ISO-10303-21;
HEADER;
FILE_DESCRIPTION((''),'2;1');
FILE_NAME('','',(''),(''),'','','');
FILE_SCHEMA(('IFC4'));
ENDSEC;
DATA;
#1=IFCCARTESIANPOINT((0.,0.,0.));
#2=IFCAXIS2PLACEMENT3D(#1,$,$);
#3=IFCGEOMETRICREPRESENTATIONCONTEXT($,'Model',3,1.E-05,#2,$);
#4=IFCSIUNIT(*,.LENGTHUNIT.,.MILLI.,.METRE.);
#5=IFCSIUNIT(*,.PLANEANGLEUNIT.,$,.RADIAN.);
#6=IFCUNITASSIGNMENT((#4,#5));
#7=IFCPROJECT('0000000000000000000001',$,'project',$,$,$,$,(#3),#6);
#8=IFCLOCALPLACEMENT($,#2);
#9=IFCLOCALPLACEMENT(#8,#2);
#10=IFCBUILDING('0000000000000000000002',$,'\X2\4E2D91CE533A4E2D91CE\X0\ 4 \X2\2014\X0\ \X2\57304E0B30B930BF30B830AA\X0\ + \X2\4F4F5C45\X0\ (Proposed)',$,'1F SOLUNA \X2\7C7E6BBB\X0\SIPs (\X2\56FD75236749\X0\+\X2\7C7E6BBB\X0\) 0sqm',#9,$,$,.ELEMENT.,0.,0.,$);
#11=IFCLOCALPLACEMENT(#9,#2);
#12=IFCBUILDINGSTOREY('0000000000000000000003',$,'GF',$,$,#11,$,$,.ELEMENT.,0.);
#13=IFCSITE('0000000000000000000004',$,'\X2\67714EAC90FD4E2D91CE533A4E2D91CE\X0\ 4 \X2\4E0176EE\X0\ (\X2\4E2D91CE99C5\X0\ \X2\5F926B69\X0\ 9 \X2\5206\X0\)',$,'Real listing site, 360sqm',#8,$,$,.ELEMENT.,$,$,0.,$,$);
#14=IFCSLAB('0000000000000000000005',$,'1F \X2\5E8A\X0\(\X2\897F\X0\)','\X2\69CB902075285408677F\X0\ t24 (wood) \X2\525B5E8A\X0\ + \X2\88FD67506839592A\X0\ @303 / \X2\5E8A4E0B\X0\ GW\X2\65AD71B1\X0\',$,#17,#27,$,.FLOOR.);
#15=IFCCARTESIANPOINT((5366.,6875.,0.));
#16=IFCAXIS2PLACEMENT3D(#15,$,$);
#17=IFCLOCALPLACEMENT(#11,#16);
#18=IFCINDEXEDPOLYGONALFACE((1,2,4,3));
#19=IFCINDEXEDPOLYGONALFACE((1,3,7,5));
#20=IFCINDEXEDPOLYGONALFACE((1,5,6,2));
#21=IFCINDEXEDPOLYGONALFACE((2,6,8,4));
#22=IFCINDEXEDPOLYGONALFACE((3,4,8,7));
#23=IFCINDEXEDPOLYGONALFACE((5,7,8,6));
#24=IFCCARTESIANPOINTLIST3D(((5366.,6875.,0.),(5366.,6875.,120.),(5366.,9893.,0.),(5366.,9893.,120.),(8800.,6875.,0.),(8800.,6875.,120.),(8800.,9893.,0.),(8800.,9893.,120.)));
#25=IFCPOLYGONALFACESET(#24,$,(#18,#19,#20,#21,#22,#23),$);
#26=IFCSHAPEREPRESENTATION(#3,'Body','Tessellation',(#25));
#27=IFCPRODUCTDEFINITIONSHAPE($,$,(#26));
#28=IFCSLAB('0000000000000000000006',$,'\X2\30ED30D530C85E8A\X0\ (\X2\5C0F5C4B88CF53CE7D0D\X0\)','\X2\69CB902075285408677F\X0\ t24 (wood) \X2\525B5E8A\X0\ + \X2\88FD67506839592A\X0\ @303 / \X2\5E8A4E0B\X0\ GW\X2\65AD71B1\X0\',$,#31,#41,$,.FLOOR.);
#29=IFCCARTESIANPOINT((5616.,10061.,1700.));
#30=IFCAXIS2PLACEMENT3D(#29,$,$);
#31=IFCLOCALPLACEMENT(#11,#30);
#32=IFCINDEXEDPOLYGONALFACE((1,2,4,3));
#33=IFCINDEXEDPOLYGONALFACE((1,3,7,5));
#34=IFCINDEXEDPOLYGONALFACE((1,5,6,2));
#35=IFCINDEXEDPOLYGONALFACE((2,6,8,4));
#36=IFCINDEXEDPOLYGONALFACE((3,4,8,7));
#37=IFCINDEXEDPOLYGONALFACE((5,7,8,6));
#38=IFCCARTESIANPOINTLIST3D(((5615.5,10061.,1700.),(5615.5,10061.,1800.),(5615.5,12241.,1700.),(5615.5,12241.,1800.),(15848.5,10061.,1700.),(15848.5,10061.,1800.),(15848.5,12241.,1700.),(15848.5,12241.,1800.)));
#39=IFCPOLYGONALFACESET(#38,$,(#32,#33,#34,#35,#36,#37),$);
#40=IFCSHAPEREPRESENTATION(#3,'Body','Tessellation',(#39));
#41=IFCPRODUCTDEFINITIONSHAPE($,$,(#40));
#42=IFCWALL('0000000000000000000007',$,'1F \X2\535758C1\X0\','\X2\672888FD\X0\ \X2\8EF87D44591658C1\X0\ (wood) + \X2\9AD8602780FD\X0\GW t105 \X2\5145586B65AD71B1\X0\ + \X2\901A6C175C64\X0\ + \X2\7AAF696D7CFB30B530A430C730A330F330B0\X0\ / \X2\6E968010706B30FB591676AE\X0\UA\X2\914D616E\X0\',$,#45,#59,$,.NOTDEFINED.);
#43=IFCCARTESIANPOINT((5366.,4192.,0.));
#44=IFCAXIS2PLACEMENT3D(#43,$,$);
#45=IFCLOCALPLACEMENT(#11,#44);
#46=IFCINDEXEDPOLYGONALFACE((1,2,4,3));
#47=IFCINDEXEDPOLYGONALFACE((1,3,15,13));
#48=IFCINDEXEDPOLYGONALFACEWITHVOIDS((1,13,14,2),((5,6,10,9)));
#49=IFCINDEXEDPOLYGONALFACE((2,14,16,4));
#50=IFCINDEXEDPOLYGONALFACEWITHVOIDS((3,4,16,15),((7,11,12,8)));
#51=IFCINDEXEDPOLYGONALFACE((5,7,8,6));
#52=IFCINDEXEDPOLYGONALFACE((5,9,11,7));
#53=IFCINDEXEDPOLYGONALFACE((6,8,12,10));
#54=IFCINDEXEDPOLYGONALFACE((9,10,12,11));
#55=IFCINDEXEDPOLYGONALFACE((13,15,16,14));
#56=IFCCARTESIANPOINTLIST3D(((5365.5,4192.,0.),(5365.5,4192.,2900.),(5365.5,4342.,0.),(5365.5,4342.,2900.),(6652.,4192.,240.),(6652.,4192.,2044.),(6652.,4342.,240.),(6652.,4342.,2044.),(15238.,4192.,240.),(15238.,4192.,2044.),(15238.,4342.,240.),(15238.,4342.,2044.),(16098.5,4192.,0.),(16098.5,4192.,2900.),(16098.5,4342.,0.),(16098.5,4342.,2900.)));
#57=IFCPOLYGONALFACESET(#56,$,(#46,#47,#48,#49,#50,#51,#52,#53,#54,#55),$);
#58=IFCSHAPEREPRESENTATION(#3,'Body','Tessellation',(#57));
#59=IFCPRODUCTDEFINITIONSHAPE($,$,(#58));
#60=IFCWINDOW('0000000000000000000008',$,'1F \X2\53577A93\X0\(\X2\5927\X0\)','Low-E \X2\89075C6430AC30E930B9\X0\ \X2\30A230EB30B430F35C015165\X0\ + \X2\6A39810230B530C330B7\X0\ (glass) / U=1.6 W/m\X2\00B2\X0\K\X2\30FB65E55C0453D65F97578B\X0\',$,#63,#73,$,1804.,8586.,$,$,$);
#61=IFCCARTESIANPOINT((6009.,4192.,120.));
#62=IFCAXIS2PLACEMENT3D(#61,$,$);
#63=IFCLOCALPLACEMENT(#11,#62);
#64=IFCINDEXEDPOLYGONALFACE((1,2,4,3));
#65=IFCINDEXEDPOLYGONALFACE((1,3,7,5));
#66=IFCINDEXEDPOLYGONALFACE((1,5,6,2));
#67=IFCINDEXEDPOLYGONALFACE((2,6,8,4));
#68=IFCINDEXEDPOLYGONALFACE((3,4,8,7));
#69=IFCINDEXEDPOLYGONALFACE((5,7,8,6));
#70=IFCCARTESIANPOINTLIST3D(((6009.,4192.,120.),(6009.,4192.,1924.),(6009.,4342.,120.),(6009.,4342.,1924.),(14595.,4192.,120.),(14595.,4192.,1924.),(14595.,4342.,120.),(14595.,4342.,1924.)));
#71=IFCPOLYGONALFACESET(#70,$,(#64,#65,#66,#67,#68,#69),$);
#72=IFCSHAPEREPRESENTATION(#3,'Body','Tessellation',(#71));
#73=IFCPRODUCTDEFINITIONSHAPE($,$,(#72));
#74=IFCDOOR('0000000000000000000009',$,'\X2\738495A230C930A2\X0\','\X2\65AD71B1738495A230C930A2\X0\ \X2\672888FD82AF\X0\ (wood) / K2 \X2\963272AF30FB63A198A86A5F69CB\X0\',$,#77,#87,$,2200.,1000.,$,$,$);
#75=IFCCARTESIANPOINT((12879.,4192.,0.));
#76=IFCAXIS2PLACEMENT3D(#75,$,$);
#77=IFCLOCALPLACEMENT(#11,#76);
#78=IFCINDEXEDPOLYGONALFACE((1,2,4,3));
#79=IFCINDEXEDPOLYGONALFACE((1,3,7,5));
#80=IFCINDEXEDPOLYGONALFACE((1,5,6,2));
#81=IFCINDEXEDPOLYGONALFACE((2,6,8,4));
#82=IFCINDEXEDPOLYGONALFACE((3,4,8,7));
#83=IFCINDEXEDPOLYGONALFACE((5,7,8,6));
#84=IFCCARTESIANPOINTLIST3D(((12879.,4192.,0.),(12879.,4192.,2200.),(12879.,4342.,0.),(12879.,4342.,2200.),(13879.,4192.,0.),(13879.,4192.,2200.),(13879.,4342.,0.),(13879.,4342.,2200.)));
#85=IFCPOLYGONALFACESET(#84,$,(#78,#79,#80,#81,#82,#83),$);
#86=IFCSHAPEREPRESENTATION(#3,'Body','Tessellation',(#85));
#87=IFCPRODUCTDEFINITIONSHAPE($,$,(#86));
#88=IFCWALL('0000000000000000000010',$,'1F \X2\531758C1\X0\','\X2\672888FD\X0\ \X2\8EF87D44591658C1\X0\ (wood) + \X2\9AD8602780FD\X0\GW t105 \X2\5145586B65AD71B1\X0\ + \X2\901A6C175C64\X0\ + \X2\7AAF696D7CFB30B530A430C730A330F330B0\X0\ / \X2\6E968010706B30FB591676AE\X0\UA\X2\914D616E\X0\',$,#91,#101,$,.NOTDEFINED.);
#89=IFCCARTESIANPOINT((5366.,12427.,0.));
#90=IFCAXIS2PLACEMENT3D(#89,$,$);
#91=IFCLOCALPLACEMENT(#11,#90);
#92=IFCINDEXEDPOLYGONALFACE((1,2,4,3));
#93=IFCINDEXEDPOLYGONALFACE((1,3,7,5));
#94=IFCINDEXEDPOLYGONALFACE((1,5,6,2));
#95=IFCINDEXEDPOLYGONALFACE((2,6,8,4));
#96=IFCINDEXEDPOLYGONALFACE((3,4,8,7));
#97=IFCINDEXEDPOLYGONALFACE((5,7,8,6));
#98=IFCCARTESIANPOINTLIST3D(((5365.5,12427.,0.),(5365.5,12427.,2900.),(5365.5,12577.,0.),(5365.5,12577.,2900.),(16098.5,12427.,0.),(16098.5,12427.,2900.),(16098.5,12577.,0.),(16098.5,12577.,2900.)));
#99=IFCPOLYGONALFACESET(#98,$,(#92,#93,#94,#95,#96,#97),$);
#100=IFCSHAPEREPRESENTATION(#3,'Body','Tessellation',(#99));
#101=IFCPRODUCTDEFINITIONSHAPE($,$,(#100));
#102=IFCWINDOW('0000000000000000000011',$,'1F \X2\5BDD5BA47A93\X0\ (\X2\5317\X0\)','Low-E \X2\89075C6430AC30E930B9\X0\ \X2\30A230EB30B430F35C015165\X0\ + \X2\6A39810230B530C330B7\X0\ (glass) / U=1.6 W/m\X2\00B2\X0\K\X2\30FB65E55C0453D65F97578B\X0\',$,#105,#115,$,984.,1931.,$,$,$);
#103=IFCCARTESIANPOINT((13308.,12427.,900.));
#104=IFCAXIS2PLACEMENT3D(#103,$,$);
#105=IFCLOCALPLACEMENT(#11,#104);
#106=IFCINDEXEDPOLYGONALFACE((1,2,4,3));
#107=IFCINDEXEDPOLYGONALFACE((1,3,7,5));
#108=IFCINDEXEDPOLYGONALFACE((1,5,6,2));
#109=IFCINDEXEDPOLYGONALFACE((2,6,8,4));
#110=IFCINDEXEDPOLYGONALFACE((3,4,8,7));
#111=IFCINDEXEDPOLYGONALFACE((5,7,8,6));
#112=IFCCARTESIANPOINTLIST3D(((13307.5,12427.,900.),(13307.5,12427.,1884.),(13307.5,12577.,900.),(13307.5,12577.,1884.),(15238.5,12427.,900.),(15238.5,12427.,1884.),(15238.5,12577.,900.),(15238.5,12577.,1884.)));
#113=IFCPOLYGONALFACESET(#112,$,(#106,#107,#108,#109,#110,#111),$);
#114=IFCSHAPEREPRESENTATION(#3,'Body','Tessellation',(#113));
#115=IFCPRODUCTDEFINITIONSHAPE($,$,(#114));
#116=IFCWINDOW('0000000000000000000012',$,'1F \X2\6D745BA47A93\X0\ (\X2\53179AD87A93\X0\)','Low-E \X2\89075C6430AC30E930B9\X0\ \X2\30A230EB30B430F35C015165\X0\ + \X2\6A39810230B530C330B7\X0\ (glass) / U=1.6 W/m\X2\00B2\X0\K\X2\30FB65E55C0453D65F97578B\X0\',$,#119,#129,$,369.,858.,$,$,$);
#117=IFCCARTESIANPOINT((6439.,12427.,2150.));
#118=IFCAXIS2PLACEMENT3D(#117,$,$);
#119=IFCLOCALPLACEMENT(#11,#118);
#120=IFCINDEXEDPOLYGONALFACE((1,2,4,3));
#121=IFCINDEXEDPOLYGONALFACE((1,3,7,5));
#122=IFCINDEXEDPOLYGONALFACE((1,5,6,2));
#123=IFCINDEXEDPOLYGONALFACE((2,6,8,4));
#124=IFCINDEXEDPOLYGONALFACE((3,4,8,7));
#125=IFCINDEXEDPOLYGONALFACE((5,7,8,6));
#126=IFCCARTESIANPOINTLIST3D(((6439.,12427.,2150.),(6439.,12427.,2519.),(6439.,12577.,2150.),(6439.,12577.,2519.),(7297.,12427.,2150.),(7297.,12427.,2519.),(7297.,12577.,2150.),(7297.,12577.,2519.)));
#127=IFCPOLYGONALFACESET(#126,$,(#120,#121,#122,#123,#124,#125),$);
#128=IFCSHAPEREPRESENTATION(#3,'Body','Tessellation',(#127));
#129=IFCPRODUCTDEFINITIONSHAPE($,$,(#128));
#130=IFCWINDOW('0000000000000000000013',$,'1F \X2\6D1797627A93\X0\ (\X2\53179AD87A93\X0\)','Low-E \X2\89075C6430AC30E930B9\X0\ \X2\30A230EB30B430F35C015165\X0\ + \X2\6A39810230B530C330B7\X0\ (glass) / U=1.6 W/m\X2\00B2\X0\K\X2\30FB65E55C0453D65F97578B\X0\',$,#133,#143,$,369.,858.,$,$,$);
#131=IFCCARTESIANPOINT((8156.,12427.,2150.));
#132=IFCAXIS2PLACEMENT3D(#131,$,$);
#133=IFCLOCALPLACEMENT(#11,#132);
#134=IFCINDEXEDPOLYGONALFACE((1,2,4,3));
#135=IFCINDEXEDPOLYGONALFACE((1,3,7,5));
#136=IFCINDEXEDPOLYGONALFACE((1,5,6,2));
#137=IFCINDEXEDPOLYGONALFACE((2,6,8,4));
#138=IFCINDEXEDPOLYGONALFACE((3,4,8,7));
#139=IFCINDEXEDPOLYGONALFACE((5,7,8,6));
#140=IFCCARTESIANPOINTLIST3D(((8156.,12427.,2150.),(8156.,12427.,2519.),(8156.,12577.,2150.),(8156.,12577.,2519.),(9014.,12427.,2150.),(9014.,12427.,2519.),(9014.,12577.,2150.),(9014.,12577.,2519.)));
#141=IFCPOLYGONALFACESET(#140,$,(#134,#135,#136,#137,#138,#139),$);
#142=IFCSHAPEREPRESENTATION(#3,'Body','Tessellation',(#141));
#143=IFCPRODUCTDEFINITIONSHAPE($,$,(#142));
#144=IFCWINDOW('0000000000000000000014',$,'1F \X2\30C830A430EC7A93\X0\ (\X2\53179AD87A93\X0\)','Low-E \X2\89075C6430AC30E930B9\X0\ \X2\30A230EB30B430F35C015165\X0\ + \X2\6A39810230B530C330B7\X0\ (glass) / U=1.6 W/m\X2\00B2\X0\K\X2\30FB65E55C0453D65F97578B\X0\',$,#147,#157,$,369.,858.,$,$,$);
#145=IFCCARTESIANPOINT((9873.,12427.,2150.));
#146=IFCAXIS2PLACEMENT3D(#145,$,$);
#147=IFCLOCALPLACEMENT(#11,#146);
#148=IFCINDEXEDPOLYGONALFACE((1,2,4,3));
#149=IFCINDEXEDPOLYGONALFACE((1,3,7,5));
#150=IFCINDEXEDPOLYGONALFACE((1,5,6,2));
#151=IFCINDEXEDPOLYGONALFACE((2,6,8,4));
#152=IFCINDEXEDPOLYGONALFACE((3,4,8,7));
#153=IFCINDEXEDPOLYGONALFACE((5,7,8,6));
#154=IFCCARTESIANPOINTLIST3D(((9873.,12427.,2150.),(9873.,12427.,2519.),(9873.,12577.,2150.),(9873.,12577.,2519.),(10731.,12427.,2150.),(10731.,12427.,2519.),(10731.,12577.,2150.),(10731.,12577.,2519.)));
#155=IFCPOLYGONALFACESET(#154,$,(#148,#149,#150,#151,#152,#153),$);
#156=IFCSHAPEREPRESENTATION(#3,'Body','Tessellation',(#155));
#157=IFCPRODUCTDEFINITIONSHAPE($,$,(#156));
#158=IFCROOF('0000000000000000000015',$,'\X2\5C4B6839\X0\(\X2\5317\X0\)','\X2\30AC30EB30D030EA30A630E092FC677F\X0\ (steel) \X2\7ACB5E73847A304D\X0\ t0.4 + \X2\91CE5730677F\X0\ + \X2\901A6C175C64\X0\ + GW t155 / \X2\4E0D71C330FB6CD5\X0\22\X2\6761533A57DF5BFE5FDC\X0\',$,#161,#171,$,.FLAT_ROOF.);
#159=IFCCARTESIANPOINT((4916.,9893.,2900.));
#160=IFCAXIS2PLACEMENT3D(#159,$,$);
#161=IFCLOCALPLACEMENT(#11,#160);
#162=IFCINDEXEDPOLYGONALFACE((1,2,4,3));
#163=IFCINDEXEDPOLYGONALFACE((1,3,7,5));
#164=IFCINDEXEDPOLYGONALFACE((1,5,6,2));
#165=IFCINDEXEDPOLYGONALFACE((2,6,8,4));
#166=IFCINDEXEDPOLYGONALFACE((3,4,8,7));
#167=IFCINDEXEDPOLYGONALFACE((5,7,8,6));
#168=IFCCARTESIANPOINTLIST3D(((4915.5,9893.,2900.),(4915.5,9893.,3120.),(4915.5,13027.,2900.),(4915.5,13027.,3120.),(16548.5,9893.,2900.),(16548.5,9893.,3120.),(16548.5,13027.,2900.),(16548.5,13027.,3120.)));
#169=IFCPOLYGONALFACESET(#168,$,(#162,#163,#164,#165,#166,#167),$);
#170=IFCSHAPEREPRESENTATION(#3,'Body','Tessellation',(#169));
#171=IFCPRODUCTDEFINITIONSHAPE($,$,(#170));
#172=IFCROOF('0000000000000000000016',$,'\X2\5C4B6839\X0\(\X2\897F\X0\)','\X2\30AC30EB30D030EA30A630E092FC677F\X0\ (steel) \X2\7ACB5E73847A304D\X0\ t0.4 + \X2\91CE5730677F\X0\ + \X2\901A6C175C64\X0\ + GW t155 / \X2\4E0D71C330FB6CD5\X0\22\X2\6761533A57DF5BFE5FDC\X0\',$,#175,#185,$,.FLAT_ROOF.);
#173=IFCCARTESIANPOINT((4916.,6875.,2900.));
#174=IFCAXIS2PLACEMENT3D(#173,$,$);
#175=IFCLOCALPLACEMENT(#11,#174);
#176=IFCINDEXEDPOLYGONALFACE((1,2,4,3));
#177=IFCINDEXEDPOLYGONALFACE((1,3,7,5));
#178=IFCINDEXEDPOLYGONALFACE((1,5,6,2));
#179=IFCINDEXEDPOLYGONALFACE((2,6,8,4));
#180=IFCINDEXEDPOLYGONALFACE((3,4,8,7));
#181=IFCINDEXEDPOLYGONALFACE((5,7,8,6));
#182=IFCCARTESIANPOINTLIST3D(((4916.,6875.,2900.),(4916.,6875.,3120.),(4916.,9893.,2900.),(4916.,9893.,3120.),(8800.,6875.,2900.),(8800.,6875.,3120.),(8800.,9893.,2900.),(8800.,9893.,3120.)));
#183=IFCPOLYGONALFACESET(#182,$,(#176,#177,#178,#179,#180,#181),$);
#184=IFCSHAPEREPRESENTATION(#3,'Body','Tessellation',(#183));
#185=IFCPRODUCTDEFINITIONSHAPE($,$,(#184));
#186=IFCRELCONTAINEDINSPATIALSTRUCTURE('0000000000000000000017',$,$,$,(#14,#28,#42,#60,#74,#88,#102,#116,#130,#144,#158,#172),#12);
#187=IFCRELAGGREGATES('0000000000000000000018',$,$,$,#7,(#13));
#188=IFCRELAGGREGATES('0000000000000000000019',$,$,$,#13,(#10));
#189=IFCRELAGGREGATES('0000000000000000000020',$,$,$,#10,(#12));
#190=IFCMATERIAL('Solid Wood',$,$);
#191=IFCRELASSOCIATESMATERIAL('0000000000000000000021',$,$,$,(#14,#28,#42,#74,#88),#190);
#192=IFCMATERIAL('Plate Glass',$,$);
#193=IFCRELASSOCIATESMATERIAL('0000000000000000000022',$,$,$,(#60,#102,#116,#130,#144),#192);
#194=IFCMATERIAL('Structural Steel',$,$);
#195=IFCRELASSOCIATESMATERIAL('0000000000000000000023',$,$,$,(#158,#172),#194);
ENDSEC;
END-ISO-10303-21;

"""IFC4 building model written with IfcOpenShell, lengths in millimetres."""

from ifc_helpers import new_model, si_unit, frame, frame_2d, origin, place, context, project, spatial, rectangle, extrude, material, element, fill, save


model = new_model("IFC4")

# Units and contexts
model_context = context("Model", 3, precision=1e-05, world=origin())
ifc_project = project(units=[si_unit("LENGTHUNIT", "METRE", prefix="MILLI"), si_unit("PLANEANGLEUNIT", "RADIAN")], contexts=[model_context])

# Site, building, storey
site_placement = place(None, origin())
site = spatial("IfcSite", under=ifc_project, at=site_placement, Name="東京都中野区中野 4 丁目 (中野駅 徒歩 9 分)", ObjectType="Real listing site, 360sqm", CompositionType="ELEMENT", RefElevation=0.0)
building_placement = place(site_placement, origin())
building = spatial("IfcBuilding", under=site, at=building_placement, Name="中野区中野 4 — 地下スタジオ + 住居 (Proposed)", ObjectType="1F SOLUNA 籾殻SIPs (国産杉+籾殻) 0sqm", CompositionType="ELEMENT", ElevationOfRefHeight=0.0, ElevationOfTerrain=0.0)
storey_placement = place(building_placement, origin())
storey = spatial("IfcBuildingStorey", under=building, at=storey_placement, Name="GF", CompositionType="ELEMENT", Elevation=0.0)

# Slabs
ifc_material_1 = material(Name="Solid Wood")
slab_1_placement = place(storey_placement, frame((5366.0, 6875.0, 0.0)))
element("IfcSlab", 1, at=slab_1_placement, inside=storey, material=ifc_material_1, Name="1F 床(西)", Description="構造用合板 t24 (wood) 剛床 + 製材根太 @303 / 床下 GW断熱", PredefinedType="FLOOR", context=model_context, shape_type="SweptSolid", body=[
    extrude(rectangle(XDim=3434.0, YDim=3018.0, at=frame_2d((1717.0, 1509.0))), frame((5366.0, 6875.0, 0.0)), (0.0, 0.0, 1.0), 120.0),
])
slab_2_placement = place(storey_placement, frame((5616.0, 10061.0, 1700.0)))
element("IfcSlab", 2, at=slab_2_placement, inside=storey, material=ifc_material_1, Name="ロフト床 (小屋裏収納)", Description="構造用合板 t24 (wood) 剛床 + 製材根太 @303 / 床下 GW断熱", PredefinedType="FLOOR", context=model_context, shape_type="SweptSolid", body=[
    extrude(rectangle(XDim=10233.0, YDim=2180.0, at=frame_2d((5116.0, 1090.0))), frame((5616.0, 10061.0, 1700.0)), (0.0, 0.0, 1.0), 100.0),
])

# Wall, openings, window, door
wall_1_placement = place(storey_placement, frame((5366.0, 4192.0, 0.0)))
wall_1 = element("IfcWall", 3, at=wall_1_placement, inside=storey, material=ifc_material_1, Name="1F 南壁", Description="木製 軸組外壁 (wood) + 高性能GW t105 充填断熱 + 通気層 + 窯業系サイディング / 準耐火・外皮UA配慮", PredefinedType="NOTDEFINED", context=model_context, shape_type="SweptSolid", body=[
    extrude(rectangle(XDim=10733.0, YDim=150.0, at=frame_2d((5366.0, 75.0))), frame((5366.0, 4192.0, 0.0)), (0.0, 0.0, 1.0), 2900.0),
])
opening_1_placement = place(storey_placement, frame((6009.0, 4192.0, 120.0)))
opening_1 = element("IfcOpeningElement", 4, at=opening_1_placement, cuts=wall_1, PredefinedType="NOTDEFINED", context=model_context, shape_type="SweptSolid", body=[
    extrude(rectangle(XDim=8586.0, YDim=150.0, at=frame_2d((4293.0, 75.0))), frame((6009.0, 4192.0, 120.0)), (0.0, 0.0, 1.0), 1804.0),
])
opening_2_placement = place(storey_placement, frame((12879.0, 4192.0, 0.0)))
opening_2 = element("IfcOpeningElement", 5, at=opening_2_placement, cuts=wall_1, PredefinedType="NOTDEFINED", context=model_context, shape_type="SweptSolid", body=[
    extrude(rectangle(XDim=1000.0, YDim=150.0, at=frame_2d((500.0, 75.0))), frame((12879.0, 4192.0, 0.0)), (0.0, 0.0, 1.0), 2200.0),
])
ifc_material_2 = material(Name="Plate Glass")
window_1_placement = place(storey_placement, frame((6009.0, 4192.0, 120.0)))
window_1 = element("IfcWindow", 6, at=window_1_placement, inside=storey, material=ifc_material_2, Name="1F 南窓(大)", Description="Low-E 複層ガラス アルゴン封入 + 樹脂サッシ (glass) / U=1.6 W/m²K・日射取得型", OverallHeight=1804.0, OverallWidth=8586.0, context=model_context, shape_type="SweptSolid", body=[
    extrude(rectangle(XDim=8586.0, YDim=150.0, at=frame_2d((4293.0, 75.0))), frame((6009.0, 4192.0, 120.0)), (0.0, 0.0, 1.0), 1804.0),
])
fill(opening_1, window_1)
door_1_placement = place(storey_placement, frame((12879.0, 4192.0, 0.0)))
door_1 = element("IfcDoor", 7, at=door_1_placement, inside=storey, material=ifc_material_1, Name="玄関ドア", Description="断熱玄関ドア 木製芯 (wood) / K2 防犯・採風機構", OverallHeight=2200.0, OverallWidth=1000.0, context=model_context, shape_type="SweptSolid", body=[
    extrude(rectangle(XDim=1000.0, YDim=150.0, at=frame_2d((500.0, 75.0))), frame((12879.0, 4192.0, 0.0)), (0.0, 0.0, 1.0), 2200.0),
])
fill(opening_2, door_1)

# Wall, openings, windows
wall_2_placement = place(storey_placement, frame((5366.0, 12427.0, 0.0)))
wall_2 = element("IfcWall", 8, at=wall_2_placement, inside=storey, material=ifc_material_1, Name="1F 北壁", Description="木製 軸組外壁 (wood) + 高性能GW t105 充填断熱 + 通気層 + 窯業系サイディング / 準耐火・外皮UA配慮", PredefinedType="NOTDEFINED", context=model_context, shape_type="SweptSolid", body=[
    extrude(rectangle(XDim=10733.0, YDim=150.0, at=frame_2d((5366.0, 75.0))), frame((5366.0, 12427.0, 0.0)), (0.0, 0.0, 1.0), 2900.0),
])
opening_3_placement = place(storey_placement, frame((13308.0, 12427.0, 900.0)))
opening_3 = element("IfcOpeningElement", 9, at=opening_3_placement, cuts=wall_2, PredefinedType="NOTDEFINED", context=model_context, shape_type="SweptSolid", body=[
    extrude(rectangle(XDim=1931.0, YDim=150.0, at=frame_2d((965.0, 75.0))), frame((13308.0, 12427.0, 900.0)), (0.0, 0.0, 1.0), 984.0),
])
opening_4_placement = place(storey_placement, frame((6439.0, 12427.0, 2150.0)))
opening_4 = element("IfcOpeningElement", 10, at=opening_4_placement, cuts=wall_2, PredefinedType="NOTDEFINED", context=model_context, shape_type="SweptSolid", body=[
    extrude(rectangle(XDim=858.0, YDim=150.0, at=frame_2d((429.0, 75.0))), frame((6439.0, 12427.0, 2150.0)), (0.0, 0.0, 1.0), 369.0),
])
opening_5_placement = place(storey_placement, frame((8156.0, 12427.0, 2150.0)))
opening_5 = element("IfcOpeningElement", 11, at=opening_5_placement, cuts=wall_2, PredefinedType="NOTDEFINED", context=model_context, shape_type="SweptSolid", body=[
    extrude(rectangle(XDim=858.0, YDim=150.0, at=frame_2d((429.0, 75.0))), frame((8156.0, 12427.0, 2150.0)), (0.0, 0.0, 1.0), 369.0),
])
opening_6_placement = place(storey_placement, frame((9873.0, 12427.0, 2150.0)))
opening_6 = element("IfcOpeningElement", 12, at=opening_6_placement, cuts=wall_2, PredefinedType="NOTDEFINED", context=model_context, shape_type="SweptSolid", body=[
    extrude(rectangle(XDim=858.0, YDim=150.0, at=frame_2d((429.0, 75.0))), frame((9873.0, 12427.0, 2150.0)), (0.0, 0.0, 1.0), 369.0),
])
window_2_placement = place(storey_placement, frame((13308.0, 12427.0, 900.0)))
window_2 = element("IfcWindow", 13, at=window_2_placement, inside=storey, material=ifc_material_2, Name="1F 寝室窓 (北)", Description="Low-E 複層ガラス アルゴン封入 + 樹脂サッシ (glass) / U=1.6 W/m²K・日射取得型", OverallHeight=984.0, OverallWidth=1931.0, context=model_context, shape_type="SweptSolid", body=[
    extrude(rectangle(XDim=1931.0, YDim=150.0, at=frame_2d((965.0, 75.0))), frame((13308.0, 12427.0, 900.0)), (0.0, 0.0, 1.0), 984.0),
])
fill(opening_3, window_2)
window_3_placement = place(storey_placement, frame((6439.0, 12427.0, 2150.0)))
window_3 = element("IfcWindow", 14, at=window_3_placement, inside=storey, material=ifc_material_2, Name="1F 浴室窓 (北高窓)", Description="Low-E 複層ガラス アルゴン封入 + 樹脂サッシ (glass) / U=1.6 W/m²K・日射取得型", OverallHeight=369.0, OverallWidth=858.0, context=model_context, shape_type="SweptSolid", body=[
    extrude(rectangle(XDim=858.0, YDim=150.0, at=frame_2d((429.0, 75.0))), frame((6439.0, 12427.0, 2150.0)), (0.0, 0.0, 1.0), 369.0),
])
fill(opening_4, window_3)
window_4_placement = place(storey_placement, frame((8156.0, 12427.0, 2150.0)))
window_4 = element("IfcWindow", 15, at=window_4_placement, inside=storey, material=ifc_material_2, Name="1F 洗面窓 (北高窓)", Description="Low-E 複層ガラス アルゴン封入 + 樹脂サッシ (glass) / U=1.6 W/m²K・日射取得型", OverallHeight=369.0, OverallWidth=858.0, context=model_context, shape_type="SweptSolid", body=[
    extrude(rectangle(XDim=858.0, YDim=150.0, at=frame_2d((429.0, 75.0))), frame((8156.0, 12427.0, 2150.0)), (0.0, 0.0, 1.0), 369.0),
])
fill(opening_5, window_4)
window_5_placement = place(storey_placement, frame((9873.0, 12427.0, 2150.0)))
window_5 = element("IfcWindow", 16, at=window_5_placement, inside=storey, material=ifc_material_2, Name="1F トイレ窓 (北高窓)", Description="Low-E 複層ガラス アルゴン封入 + 樹脂サッシ (glass) / U=1.6 W/m²K・日射取得型", OverallHeight=369.0, OverallWidth=858.0, context=model_context, shape_type="SweptSolid", body=[
    extrude(rectangle(XDim=858.0, YDim=150.0, at=frame_2d((429.0, 75.0))), frame((9873.0, 12427.0, 2150.0)), (0.0, 0.0, 1.0), 369.0),
])
fill(opening_6, window_5)

# Roofs
ifc_material_3 = material(Name="Structural Steel")
roof_1_placement = place(storey_placement, frame((4916.0, 9893.0, 2900.0)))
element("IfcRoof", 17, at=roof_1_placement, inside=storey, material=ifc_material_3, Name="屋根(北)", Description="ガルバリウム鋼板 (steel) 立平葺き t0.4 + 野地板 + 通気層 + GW t155 / 不燃・法22条区域対応", PredefinedType="FLAT_ROOF", context=model_context, shape_type="SweptSolid", body=[
    extrude(rectangle(XDim=11633.0, YDim=3134.0, at=frame_2d((5816.0, 1567.0))), frame((4916.0, 9893.0, 2900.0)), (0.0, 0.0, 1.0), 220.0),
])
roof_2_placement = place(storey_placement, frame((4916.0, 6875.0, 2900.0)))
element("IfcRoof", 18, at=roof_2_placement, inside=storey, material=ifc_material_3, Name="屋根(西)", Description="ガルバリウム鋼板 (steel) 立平葺き t0.4 + 野地板 + 通気層 + GW t155 / 不燃・法22条区域対応", PredefinedType="FLAT_ROOF", context=model_context, shape_type="SweptSolid", body=[
    extrude(rectangle(XDim=3884.0, YDim=3018.0, at=frame_2d((1942.0, 1509.0))), frame((4916.0, 6875.0, 2900.0)), (0.0, 0.0, 1.0), 220.0),
])

save(model, "model.ifc")
